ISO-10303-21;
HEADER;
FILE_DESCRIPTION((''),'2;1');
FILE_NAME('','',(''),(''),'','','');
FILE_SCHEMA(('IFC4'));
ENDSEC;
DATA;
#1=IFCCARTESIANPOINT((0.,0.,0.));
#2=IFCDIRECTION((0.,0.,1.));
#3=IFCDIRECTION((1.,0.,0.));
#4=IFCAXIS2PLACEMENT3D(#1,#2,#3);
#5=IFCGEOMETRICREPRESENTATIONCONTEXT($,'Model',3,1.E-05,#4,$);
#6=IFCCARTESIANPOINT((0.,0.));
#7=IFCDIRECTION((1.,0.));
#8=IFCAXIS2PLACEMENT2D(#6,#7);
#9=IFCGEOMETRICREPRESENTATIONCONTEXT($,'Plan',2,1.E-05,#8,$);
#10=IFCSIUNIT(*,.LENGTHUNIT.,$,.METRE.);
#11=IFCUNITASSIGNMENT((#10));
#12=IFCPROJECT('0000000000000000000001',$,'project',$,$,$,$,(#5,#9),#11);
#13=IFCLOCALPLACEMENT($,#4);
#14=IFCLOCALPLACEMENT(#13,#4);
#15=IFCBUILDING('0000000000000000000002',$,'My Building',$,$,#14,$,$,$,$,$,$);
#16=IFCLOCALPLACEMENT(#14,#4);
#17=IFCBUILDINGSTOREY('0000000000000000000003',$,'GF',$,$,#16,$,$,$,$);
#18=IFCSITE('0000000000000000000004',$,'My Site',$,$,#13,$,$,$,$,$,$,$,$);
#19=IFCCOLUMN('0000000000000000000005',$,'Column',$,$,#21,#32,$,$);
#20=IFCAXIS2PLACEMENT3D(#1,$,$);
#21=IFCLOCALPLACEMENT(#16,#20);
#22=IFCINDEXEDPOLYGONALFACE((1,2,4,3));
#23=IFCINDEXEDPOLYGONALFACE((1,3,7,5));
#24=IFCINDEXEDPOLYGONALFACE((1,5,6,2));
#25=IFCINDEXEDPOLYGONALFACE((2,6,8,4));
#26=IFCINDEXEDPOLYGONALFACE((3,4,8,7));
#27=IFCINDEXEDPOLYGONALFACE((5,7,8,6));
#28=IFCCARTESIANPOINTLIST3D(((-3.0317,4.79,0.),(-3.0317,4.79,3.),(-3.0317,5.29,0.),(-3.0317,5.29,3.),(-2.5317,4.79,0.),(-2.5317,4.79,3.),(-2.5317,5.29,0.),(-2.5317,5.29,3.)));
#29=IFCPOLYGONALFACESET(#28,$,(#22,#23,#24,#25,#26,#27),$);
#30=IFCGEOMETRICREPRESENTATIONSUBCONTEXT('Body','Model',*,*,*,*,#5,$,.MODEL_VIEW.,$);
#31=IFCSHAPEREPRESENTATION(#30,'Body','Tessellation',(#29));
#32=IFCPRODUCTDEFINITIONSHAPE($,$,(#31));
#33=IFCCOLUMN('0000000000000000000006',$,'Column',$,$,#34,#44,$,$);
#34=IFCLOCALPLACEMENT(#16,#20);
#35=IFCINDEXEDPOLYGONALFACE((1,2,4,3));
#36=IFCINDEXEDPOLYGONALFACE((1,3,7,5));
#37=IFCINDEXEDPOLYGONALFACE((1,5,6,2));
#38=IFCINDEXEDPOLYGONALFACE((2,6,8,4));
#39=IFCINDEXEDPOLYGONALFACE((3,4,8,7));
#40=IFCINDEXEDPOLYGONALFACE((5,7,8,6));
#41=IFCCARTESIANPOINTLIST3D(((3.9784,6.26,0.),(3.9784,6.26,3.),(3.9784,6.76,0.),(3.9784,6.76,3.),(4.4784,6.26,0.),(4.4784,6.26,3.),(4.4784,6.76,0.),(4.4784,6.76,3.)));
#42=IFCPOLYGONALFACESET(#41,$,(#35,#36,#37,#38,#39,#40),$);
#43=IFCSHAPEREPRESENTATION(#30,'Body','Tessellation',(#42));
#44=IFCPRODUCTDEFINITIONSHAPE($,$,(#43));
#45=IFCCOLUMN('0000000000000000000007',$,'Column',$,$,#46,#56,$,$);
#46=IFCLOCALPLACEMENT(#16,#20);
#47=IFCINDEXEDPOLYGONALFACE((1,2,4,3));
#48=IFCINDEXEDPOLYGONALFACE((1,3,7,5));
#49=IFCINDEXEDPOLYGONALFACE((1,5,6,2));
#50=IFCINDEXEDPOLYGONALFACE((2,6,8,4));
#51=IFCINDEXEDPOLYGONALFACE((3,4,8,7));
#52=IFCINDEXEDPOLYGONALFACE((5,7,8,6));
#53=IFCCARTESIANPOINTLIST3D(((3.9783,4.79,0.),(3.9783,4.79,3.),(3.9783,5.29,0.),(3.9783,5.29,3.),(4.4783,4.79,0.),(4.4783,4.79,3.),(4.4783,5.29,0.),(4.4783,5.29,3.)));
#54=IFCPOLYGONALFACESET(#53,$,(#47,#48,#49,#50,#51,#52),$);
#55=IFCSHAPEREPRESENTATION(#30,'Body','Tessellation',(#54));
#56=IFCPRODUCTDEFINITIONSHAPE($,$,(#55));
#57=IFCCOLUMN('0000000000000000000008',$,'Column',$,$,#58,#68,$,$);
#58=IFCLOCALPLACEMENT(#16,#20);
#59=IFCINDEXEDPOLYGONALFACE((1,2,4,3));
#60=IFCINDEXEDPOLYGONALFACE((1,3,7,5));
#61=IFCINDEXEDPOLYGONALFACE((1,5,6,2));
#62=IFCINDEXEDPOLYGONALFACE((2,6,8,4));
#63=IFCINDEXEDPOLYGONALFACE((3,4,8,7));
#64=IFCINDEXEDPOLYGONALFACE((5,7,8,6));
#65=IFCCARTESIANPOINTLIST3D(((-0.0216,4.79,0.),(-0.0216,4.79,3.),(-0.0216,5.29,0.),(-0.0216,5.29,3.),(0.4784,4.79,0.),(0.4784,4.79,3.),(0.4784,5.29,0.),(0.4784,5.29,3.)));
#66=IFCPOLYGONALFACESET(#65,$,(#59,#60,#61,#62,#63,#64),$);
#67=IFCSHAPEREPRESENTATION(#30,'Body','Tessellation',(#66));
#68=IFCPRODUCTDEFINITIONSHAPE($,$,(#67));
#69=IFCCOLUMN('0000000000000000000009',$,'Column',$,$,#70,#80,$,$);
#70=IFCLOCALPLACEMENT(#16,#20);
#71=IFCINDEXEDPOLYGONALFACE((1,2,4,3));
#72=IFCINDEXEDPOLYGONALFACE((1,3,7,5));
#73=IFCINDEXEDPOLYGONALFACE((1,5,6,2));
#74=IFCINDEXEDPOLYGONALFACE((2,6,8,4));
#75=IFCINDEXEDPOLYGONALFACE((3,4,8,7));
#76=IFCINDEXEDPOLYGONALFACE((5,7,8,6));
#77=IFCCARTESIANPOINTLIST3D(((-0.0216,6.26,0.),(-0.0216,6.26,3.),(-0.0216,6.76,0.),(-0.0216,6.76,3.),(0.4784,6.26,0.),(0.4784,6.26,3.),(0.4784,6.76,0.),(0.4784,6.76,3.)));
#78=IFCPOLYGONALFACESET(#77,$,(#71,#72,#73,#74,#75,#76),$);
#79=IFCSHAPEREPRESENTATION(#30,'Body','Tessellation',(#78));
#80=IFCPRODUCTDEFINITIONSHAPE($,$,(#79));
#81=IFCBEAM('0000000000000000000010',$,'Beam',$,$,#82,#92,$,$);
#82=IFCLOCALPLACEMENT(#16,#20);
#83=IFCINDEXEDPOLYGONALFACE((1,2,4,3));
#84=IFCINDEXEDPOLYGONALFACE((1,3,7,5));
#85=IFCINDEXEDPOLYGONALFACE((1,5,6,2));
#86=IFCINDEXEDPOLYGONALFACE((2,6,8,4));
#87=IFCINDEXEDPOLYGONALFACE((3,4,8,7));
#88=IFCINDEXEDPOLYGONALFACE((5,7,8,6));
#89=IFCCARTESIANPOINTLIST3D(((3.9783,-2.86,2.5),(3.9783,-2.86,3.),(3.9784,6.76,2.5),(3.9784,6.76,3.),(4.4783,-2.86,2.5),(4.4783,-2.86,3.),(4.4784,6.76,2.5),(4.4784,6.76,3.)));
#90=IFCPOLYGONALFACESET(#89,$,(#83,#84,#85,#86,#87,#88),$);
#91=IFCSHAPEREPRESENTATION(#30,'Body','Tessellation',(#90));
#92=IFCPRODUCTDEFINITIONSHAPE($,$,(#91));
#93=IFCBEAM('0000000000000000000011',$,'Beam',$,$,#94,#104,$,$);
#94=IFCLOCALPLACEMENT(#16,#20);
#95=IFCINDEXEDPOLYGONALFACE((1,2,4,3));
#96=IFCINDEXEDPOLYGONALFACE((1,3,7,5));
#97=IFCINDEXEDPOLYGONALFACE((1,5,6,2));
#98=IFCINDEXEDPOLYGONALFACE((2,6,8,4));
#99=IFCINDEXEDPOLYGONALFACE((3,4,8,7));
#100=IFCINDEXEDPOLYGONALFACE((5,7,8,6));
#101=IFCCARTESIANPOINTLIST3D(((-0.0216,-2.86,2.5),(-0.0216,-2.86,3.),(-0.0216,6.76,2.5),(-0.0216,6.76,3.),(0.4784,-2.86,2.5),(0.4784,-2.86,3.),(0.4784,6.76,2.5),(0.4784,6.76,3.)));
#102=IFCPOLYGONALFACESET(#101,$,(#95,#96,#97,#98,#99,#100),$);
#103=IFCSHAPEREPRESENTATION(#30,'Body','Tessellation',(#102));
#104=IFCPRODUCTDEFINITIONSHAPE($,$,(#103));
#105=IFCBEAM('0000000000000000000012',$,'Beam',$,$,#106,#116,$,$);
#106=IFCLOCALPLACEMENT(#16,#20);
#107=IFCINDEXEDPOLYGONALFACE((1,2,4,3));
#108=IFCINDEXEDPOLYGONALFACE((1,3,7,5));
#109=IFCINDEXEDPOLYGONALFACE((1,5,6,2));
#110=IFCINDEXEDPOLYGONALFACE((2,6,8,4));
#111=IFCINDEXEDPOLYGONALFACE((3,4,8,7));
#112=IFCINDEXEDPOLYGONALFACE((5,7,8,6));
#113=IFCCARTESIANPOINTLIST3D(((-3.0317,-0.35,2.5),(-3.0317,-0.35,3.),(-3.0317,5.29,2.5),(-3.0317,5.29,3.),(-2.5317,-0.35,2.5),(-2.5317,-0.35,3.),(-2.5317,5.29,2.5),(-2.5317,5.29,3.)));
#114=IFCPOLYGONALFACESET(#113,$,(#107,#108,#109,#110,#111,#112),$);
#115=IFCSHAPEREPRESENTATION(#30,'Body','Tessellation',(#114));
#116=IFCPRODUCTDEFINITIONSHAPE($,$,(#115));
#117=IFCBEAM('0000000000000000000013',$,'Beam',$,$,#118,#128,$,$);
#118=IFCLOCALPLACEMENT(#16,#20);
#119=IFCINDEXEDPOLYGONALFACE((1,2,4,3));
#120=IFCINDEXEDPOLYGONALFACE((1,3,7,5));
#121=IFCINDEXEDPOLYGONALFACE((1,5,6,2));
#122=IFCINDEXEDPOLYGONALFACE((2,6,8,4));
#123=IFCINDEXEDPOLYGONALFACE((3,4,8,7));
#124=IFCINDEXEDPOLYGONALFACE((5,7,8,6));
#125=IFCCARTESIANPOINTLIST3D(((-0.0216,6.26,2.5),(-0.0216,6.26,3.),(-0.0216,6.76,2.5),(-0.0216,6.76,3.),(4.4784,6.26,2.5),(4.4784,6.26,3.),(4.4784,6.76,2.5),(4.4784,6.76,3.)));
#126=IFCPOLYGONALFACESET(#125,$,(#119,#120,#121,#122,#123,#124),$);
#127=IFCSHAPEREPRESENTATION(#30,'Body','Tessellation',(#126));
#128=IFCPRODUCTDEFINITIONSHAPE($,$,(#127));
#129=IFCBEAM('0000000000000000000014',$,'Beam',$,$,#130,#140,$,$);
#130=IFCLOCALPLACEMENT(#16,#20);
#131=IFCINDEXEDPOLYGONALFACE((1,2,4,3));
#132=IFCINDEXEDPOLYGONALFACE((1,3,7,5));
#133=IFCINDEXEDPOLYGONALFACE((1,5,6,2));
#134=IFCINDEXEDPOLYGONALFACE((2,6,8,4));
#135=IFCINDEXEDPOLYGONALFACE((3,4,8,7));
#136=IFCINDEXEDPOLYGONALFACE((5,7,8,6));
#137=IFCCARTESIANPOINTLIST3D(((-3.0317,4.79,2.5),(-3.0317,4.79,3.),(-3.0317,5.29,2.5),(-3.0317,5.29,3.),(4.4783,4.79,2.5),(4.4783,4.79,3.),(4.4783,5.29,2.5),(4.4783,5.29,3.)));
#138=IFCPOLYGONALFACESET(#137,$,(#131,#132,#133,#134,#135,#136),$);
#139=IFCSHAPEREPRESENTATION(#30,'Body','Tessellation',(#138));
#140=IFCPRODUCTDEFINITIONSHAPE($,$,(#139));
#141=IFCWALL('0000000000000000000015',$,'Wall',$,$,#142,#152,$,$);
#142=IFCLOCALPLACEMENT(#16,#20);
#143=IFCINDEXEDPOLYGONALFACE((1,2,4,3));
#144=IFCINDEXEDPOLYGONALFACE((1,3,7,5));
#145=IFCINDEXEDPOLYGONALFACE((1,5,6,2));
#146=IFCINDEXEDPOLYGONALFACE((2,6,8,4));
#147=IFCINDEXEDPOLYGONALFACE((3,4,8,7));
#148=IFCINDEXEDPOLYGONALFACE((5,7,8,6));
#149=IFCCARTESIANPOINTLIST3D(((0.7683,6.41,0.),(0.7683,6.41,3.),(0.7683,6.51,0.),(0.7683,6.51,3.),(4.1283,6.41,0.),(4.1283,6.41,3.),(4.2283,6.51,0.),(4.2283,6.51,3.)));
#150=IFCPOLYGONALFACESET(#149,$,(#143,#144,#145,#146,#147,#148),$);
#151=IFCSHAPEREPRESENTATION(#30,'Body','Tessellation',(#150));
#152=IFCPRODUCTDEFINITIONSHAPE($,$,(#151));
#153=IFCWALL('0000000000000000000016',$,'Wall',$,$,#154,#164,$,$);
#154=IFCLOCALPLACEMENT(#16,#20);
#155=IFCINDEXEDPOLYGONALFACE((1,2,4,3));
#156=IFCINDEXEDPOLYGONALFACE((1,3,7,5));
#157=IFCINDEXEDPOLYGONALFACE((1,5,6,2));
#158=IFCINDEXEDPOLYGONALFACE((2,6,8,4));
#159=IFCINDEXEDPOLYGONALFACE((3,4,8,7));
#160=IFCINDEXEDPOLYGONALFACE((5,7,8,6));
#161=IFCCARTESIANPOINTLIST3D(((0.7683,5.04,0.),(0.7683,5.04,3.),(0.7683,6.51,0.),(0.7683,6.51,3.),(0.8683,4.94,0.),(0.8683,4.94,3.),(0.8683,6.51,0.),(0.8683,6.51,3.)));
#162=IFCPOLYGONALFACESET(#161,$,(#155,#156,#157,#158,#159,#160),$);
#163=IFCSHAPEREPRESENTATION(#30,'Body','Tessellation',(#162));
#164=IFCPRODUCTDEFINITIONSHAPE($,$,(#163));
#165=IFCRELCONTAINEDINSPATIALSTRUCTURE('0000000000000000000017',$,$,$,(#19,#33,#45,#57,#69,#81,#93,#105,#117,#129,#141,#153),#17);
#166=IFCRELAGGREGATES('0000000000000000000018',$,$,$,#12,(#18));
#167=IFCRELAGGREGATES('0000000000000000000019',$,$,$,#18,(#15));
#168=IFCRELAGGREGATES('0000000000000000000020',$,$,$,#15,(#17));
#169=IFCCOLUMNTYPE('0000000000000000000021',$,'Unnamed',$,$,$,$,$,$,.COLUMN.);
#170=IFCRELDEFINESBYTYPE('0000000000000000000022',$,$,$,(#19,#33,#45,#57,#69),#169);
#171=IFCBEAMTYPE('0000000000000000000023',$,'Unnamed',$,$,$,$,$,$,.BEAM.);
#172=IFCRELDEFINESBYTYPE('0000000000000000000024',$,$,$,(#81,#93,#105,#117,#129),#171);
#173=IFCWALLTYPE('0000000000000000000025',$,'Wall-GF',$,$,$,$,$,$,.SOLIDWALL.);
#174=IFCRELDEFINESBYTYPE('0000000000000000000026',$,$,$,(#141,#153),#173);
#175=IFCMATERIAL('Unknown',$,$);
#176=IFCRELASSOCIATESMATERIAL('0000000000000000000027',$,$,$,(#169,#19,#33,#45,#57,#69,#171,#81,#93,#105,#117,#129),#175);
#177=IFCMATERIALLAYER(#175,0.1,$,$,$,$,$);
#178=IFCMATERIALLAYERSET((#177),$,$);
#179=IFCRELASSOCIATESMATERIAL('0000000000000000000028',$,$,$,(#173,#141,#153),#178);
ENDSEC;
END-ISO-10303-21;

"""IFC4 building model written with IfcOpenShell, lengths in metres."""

from ifc_helpers import new_model, si_unit, frame, origin_with_axes, origin_2d_with_axis, place, context, subcontext, project, spatial, line, indexed_curve, rectangle, outline, extrude, material, layer, layer_set, layer_usage, material_profile, profile_set, profile_usage, type_object, element, save


model = new_model("IFC4")

# Units and contexts
model_context = context("Model", 3, precision=1e-05, world=origin_with_axes())
plan_context = context("Plan", 2, precision=1e-05, world=origin_2d_with_axis())
body_context_1 = subcontext(model_context, "Body", "Model", "MODEL_VIEW")
ifc_project = project(units=[si_unit("LENGTHUNIT", "METRE")], contexts=[model_context, plan_context])

# Site, building, storey
site_placement = place(None, origin_with_axes())
site = spatial("IfcSite", under=ifc_project, at=site_placement, Name="My Site")
building_placement = place(site_placement, origin_with_axes())
building = spatial("IfcBuilding", under=site, at=building_placement, Name="My Building")
storey_placement = place(building_placement, origin_with_axes())
storey = spatial("IfcBuildingStorey", under=building, at=storey_placement, Name="GF")

# Columns
ifc_material_1 = material(Name="Unknown")
ifc_material_profile_1 = material_profile(ifc_material_1, rectangle(XDim=0.5, YDim=0.5))
ifc_profile_set_1 = profile_set([ifc_material_profile_1])
ifc_profile_usage_1 = profile_usage(ifc_profile_set_1, cardinal=5)
column_type = type_object("IfcColumnType", Name="Unnamed", PredefinedType="COLUMN", material=ifc_profile_set_1)
column_1_placement = place(storey_placement, frame((-2.7817, 5.04, 0.0), z_axis=(0.0, 0.0, 1.0), x_axis=(1.0, 0.0, 0.0)))
element("IfcColumn", 1, at=column_1_placement, inside=storey, type_object=column_type, material=ifc_profile_usage_1, Name="Column", context=body_context_1, shape_type="SweptSolid", body=[
    extrude(rectangle(XDim=0.5, YDim=0.5), origin_with_axes(), (0.0, 0.0, 1.0), 3.0),
])
ifc_profile_usage_2 = profile_usage(ifc_profile_set_1, cardinal=5)
column_2_placement = place(storey_placement, frame((4.2284, 6.51, 0.0), z_axis=(0.0, 0.0, 1.0), x_axis=(1.0, 0.0, 0.0)))
element("IfcColumn", 2, at=column_2_placement, inside=storey, type_object=column_type, material=ifc_profile_usage_2, Name="Column", context=body_context_1, shape_type="SweptSolid", body=[
    extrude(rectangle(XDim=0.5, YDim=0.5), origin_with_axes(), (0.0, 0.0, 1.0), 3.0),
])
ifc_profile_usage_3 = profile_usage(ifc_profile_set_1, cardinal=5)
column_3_placement = place(storey_placement, frame((4.2283, 5.04, 0.0), z_axis=(0.0, 0.0, 1.0), x_axis=(1.0, 0.0, 0.0)))
element("IfcColumn", 3, at=column_3_placement, inside=storey, type_object=column_type, material=ifc_profile_usage_3, Name="Column", context=body_context_1, shape_type="SweptSolid", body=[
    extrude(rectangle(XDim=0.5, YDim=0.5), origin_with_axes(), (0.0, 0.0, 1.0), 3.0),
])
ifc_profile_usage_4 = profile_usage(ifc_profile_set_1, cardinal=5)
column_4_placement = place(storey_placement, frame((0.2284, 5.04, 0.0), z_axis=(0.0, 0.0, 1.0), x_axis=(1.0, 0.0, 0.0)))
element("IfcColumn", 4, at=column_4_placement, inside=storey, type_object=column_type, material=ifc_profile_usage_4, Name="Column", context=body_context_1, shape_type="SweptSolid", body=[
    extrude(rectangle(XDim=0.5, YDim=0.5), origin_with_axes(), (0.0, 0.0, 1.0), 3.0),
])
ifc_profile_usage_5 = profile_usage(ifc_profile_set_1, cardinal=5)
column_5_placement = place(storey_placement, frame((0.2284, 6.51, 0.0), z_axis=(0.0, 0.0, 1.0), x_axis=(1.0, 0.0, 0.0)))
element("IfcColumn", 5, at=column_5_placement, inside=storey, type_object=column_type, material=ifc_profile_usage_5, Name="Column", context=body_context_1, shape_type="SweptSolid", body=[
    extrude(rectangle(XDim=0.5, YDim=0.5), origin_with_axes(), (0.0, 0.0, 1.0), 3.0),
])

# Beams
ifc_material_profile_2 = material_profile(ifc_material_1, rectangle(XDim=0.5, YDim=0.5))
ifc_profile_set_2 = profile_set([ifc_material_profile_2])
ifc_profile_usage_6 = profile_usage(ifc_profile_set_2, cardinal=7)
beam_type = type_object("IfcBeamType", Name="Unnamed", PredefinedType="BEAM", material=ifc_profile_set_2)
beam_1_placement = place(storey_placement, frame((4.4784, 6.76, 3.0), z_axis=(0.0, -1.0, 0.0), x_axis=(1.0, 0.0, 0.0)))
element("IfcBeam", 6, at=beam_1_placement, inside=storey, type_object=beam_type, material=ifc_profile_usage_6, Name="Beam", context=body_context_1, shape_type="SweptSolid", body=[
    extrude(rectangle(XDim=0.5, YDim=0.5), frame((-0.25, -0.25, 0.0), z_axis=(0.0, 0.0, 1.0), x_axis=(1.0, 0.0, 0.0)), (0.0, 0.0, 1.0), 9.62),
])
ifc_profile_usage_7 = profile_usage(ifc_profile_set_2, cardinal=7)
beam_2_placement = place(storey_placement, frame((0.4784, 6.76, 3.0), z_axis=(0.0, -1.0, 0.0), x_axis=(1.0, 0.0, 0.0)))
element("IfcBeam", 7, at=beam_2_placement, inside=storey, type_object=beam_type, material=ifc_profile_usage_7, Name="Beam", context=body_context_1, shape_type="SweptSolid", body=[
    extrude(rectangle(XDim=0.5, YDim=0.5), frame((-0.25, -0.25, 0.0), z_axis=(0.0, 0.0, 1.0), x_axis=(1.0, 0.0, 0.0)), (0.0, 0.0, 1.0), 9.62),
])
ifc_profile_usage_8 = profile_usage(ifc_profile_set_2, cardinal=7)
beam_3_placement = place(storey_placement, frame((-2.5317, 5.29, 3.0), z_axis=(0.0, -1.0, 0.0), x_axis=(1.0, 0.0, 0.0)))
element("IfcBeam", 8, at=beam_3_placement, inside=storey, type_object=beam_type, material=ifc_profile_usage_8, Name="Beam", context=body_context_1, shape_type="SweptSolid", body=[
    extrude(rectangle(XDim=0.5, YDim=0.5), frame((-0.25, -0.25, 0.0), z_axis=(0.0, 0.0, 1.0), x_axis=(1.0, 0.0, 0.0)), (0.0, 0.0, 1.0), 5.64),
])
ifc_profile_usage_9 = profile_usage(ifc_profile_set_2, cardinal=9)
beam_4_placement = place(storey_placement, frame((-0.0216, 6.26, 3.0), z_axis=(1.0, 0.0, 0.0), x_axis=(0.0, 1.0, 0.0)))
element("IfcBeam", 9, at=beam_4_placement, inside=storey, type_object=beam_type, material=ifc_profile_usage_9, Name="Beam", context=body_context_1, shape_type="SweptSolid", body=[
    extrude(rectangle(XDim=0.5, YDim=0.5), frame((0.25, -0.25, 0.0), z_axis=(0.0, 0.0, 1.0), x_axis=(1.0, 0.0, 0.0)), (0.0, 0.0, 1.0), 4.5),
])
ifc_profile_usage_10 = profile_usage(ifc_profile_set_2, cardinal=7)
beam_5_placement = place(storey_placement, frame((4.4783, 4.79, 3.0), z_axis=(-1.0, 0.0, 0.0), x_axis=(0.0, -1.0, 0.0)))
element("IfcBeam", 10, at=beam_5_placement, inside=storey, type_object=beam_type, material=ifc_profile_usage_10, Name="Beam", context=body_context_1, shape_type="SweptSolid", body=[
    extrude(rectangle(XDim=0.5, YDim=0.5), frame((-0.25, -0.25, 0.0), z_axis=(0.0, 0.0, 1.0), x_axis=(1.0, 0.0, 0.0)), (0.0, 0.0, 1.0), 7.51),
])

# Walls
ifc_layer_1 = layer(ifc_material_1, 0.1)
ifc_layer_set_1 = layer_set([ifc_layer_1])
ifc_layer_usage_1 = layer_usage(ifc_layer_set_1, "AXIS2", "POSITIVE", 0.0)
wall_type = type_object("IfcWallType", Name="Wall-GF", PredefinedType="SOLIDWALL", material=ifc_layer_set_1)
wall_1_placement = place(storey_placement, frame((4.2283, 6.51, 0.0), z_axis=(0.0, 0.0, 1.0), x_axis=(-1.0, 0.0, 0.0)))
element("IfcWall", 11, at=wall_1_placement, inside=storey, type_object=wall_type, material=ifc_layer_usage_1, Name="Wall", context=body_context_1, shape_type="SweptSolid", body=[
    extrude(outline(indexed_curve([(0.0, 0.0), (0.1, 0.1), (3.46, 0.1), (3.46, 0.0)], segments=[line(1, 2, 3, 4, 1)])), origin_with_axes(), (0.0, 0.0, 1.0), 3.0),
])
ifc_layer_usage_2 = layer_usage(ifc_layer_set_1, "AXIS2", "POSITIVE", 0.0)
wall_2_placement = place(storey_placement, frame((0.7683, 6.51, 0.0), z_axis=(0.0, 0.0, 1.0), x_axis=(0.0, -1.0, 0.0)))
element("IfcWall", 12, at=wall_2_placement, inside=storey, type_object=wall_type, material=ifc_layer_usage_2, Name="Wall", context=body_context_1, shape_type="SweptSolid", body=[
    extrude(outline(indexed_curve([(0.0, 0.0), (0.0, 0.1), (1.57, 0.1), (1.47, 0.0)], segments=[line(1, 2, 3, 4, 1)])), origin_with_axes(), (0.0, 0.0, 1.0), 3.0),
])

save(model, "model.ifc")
